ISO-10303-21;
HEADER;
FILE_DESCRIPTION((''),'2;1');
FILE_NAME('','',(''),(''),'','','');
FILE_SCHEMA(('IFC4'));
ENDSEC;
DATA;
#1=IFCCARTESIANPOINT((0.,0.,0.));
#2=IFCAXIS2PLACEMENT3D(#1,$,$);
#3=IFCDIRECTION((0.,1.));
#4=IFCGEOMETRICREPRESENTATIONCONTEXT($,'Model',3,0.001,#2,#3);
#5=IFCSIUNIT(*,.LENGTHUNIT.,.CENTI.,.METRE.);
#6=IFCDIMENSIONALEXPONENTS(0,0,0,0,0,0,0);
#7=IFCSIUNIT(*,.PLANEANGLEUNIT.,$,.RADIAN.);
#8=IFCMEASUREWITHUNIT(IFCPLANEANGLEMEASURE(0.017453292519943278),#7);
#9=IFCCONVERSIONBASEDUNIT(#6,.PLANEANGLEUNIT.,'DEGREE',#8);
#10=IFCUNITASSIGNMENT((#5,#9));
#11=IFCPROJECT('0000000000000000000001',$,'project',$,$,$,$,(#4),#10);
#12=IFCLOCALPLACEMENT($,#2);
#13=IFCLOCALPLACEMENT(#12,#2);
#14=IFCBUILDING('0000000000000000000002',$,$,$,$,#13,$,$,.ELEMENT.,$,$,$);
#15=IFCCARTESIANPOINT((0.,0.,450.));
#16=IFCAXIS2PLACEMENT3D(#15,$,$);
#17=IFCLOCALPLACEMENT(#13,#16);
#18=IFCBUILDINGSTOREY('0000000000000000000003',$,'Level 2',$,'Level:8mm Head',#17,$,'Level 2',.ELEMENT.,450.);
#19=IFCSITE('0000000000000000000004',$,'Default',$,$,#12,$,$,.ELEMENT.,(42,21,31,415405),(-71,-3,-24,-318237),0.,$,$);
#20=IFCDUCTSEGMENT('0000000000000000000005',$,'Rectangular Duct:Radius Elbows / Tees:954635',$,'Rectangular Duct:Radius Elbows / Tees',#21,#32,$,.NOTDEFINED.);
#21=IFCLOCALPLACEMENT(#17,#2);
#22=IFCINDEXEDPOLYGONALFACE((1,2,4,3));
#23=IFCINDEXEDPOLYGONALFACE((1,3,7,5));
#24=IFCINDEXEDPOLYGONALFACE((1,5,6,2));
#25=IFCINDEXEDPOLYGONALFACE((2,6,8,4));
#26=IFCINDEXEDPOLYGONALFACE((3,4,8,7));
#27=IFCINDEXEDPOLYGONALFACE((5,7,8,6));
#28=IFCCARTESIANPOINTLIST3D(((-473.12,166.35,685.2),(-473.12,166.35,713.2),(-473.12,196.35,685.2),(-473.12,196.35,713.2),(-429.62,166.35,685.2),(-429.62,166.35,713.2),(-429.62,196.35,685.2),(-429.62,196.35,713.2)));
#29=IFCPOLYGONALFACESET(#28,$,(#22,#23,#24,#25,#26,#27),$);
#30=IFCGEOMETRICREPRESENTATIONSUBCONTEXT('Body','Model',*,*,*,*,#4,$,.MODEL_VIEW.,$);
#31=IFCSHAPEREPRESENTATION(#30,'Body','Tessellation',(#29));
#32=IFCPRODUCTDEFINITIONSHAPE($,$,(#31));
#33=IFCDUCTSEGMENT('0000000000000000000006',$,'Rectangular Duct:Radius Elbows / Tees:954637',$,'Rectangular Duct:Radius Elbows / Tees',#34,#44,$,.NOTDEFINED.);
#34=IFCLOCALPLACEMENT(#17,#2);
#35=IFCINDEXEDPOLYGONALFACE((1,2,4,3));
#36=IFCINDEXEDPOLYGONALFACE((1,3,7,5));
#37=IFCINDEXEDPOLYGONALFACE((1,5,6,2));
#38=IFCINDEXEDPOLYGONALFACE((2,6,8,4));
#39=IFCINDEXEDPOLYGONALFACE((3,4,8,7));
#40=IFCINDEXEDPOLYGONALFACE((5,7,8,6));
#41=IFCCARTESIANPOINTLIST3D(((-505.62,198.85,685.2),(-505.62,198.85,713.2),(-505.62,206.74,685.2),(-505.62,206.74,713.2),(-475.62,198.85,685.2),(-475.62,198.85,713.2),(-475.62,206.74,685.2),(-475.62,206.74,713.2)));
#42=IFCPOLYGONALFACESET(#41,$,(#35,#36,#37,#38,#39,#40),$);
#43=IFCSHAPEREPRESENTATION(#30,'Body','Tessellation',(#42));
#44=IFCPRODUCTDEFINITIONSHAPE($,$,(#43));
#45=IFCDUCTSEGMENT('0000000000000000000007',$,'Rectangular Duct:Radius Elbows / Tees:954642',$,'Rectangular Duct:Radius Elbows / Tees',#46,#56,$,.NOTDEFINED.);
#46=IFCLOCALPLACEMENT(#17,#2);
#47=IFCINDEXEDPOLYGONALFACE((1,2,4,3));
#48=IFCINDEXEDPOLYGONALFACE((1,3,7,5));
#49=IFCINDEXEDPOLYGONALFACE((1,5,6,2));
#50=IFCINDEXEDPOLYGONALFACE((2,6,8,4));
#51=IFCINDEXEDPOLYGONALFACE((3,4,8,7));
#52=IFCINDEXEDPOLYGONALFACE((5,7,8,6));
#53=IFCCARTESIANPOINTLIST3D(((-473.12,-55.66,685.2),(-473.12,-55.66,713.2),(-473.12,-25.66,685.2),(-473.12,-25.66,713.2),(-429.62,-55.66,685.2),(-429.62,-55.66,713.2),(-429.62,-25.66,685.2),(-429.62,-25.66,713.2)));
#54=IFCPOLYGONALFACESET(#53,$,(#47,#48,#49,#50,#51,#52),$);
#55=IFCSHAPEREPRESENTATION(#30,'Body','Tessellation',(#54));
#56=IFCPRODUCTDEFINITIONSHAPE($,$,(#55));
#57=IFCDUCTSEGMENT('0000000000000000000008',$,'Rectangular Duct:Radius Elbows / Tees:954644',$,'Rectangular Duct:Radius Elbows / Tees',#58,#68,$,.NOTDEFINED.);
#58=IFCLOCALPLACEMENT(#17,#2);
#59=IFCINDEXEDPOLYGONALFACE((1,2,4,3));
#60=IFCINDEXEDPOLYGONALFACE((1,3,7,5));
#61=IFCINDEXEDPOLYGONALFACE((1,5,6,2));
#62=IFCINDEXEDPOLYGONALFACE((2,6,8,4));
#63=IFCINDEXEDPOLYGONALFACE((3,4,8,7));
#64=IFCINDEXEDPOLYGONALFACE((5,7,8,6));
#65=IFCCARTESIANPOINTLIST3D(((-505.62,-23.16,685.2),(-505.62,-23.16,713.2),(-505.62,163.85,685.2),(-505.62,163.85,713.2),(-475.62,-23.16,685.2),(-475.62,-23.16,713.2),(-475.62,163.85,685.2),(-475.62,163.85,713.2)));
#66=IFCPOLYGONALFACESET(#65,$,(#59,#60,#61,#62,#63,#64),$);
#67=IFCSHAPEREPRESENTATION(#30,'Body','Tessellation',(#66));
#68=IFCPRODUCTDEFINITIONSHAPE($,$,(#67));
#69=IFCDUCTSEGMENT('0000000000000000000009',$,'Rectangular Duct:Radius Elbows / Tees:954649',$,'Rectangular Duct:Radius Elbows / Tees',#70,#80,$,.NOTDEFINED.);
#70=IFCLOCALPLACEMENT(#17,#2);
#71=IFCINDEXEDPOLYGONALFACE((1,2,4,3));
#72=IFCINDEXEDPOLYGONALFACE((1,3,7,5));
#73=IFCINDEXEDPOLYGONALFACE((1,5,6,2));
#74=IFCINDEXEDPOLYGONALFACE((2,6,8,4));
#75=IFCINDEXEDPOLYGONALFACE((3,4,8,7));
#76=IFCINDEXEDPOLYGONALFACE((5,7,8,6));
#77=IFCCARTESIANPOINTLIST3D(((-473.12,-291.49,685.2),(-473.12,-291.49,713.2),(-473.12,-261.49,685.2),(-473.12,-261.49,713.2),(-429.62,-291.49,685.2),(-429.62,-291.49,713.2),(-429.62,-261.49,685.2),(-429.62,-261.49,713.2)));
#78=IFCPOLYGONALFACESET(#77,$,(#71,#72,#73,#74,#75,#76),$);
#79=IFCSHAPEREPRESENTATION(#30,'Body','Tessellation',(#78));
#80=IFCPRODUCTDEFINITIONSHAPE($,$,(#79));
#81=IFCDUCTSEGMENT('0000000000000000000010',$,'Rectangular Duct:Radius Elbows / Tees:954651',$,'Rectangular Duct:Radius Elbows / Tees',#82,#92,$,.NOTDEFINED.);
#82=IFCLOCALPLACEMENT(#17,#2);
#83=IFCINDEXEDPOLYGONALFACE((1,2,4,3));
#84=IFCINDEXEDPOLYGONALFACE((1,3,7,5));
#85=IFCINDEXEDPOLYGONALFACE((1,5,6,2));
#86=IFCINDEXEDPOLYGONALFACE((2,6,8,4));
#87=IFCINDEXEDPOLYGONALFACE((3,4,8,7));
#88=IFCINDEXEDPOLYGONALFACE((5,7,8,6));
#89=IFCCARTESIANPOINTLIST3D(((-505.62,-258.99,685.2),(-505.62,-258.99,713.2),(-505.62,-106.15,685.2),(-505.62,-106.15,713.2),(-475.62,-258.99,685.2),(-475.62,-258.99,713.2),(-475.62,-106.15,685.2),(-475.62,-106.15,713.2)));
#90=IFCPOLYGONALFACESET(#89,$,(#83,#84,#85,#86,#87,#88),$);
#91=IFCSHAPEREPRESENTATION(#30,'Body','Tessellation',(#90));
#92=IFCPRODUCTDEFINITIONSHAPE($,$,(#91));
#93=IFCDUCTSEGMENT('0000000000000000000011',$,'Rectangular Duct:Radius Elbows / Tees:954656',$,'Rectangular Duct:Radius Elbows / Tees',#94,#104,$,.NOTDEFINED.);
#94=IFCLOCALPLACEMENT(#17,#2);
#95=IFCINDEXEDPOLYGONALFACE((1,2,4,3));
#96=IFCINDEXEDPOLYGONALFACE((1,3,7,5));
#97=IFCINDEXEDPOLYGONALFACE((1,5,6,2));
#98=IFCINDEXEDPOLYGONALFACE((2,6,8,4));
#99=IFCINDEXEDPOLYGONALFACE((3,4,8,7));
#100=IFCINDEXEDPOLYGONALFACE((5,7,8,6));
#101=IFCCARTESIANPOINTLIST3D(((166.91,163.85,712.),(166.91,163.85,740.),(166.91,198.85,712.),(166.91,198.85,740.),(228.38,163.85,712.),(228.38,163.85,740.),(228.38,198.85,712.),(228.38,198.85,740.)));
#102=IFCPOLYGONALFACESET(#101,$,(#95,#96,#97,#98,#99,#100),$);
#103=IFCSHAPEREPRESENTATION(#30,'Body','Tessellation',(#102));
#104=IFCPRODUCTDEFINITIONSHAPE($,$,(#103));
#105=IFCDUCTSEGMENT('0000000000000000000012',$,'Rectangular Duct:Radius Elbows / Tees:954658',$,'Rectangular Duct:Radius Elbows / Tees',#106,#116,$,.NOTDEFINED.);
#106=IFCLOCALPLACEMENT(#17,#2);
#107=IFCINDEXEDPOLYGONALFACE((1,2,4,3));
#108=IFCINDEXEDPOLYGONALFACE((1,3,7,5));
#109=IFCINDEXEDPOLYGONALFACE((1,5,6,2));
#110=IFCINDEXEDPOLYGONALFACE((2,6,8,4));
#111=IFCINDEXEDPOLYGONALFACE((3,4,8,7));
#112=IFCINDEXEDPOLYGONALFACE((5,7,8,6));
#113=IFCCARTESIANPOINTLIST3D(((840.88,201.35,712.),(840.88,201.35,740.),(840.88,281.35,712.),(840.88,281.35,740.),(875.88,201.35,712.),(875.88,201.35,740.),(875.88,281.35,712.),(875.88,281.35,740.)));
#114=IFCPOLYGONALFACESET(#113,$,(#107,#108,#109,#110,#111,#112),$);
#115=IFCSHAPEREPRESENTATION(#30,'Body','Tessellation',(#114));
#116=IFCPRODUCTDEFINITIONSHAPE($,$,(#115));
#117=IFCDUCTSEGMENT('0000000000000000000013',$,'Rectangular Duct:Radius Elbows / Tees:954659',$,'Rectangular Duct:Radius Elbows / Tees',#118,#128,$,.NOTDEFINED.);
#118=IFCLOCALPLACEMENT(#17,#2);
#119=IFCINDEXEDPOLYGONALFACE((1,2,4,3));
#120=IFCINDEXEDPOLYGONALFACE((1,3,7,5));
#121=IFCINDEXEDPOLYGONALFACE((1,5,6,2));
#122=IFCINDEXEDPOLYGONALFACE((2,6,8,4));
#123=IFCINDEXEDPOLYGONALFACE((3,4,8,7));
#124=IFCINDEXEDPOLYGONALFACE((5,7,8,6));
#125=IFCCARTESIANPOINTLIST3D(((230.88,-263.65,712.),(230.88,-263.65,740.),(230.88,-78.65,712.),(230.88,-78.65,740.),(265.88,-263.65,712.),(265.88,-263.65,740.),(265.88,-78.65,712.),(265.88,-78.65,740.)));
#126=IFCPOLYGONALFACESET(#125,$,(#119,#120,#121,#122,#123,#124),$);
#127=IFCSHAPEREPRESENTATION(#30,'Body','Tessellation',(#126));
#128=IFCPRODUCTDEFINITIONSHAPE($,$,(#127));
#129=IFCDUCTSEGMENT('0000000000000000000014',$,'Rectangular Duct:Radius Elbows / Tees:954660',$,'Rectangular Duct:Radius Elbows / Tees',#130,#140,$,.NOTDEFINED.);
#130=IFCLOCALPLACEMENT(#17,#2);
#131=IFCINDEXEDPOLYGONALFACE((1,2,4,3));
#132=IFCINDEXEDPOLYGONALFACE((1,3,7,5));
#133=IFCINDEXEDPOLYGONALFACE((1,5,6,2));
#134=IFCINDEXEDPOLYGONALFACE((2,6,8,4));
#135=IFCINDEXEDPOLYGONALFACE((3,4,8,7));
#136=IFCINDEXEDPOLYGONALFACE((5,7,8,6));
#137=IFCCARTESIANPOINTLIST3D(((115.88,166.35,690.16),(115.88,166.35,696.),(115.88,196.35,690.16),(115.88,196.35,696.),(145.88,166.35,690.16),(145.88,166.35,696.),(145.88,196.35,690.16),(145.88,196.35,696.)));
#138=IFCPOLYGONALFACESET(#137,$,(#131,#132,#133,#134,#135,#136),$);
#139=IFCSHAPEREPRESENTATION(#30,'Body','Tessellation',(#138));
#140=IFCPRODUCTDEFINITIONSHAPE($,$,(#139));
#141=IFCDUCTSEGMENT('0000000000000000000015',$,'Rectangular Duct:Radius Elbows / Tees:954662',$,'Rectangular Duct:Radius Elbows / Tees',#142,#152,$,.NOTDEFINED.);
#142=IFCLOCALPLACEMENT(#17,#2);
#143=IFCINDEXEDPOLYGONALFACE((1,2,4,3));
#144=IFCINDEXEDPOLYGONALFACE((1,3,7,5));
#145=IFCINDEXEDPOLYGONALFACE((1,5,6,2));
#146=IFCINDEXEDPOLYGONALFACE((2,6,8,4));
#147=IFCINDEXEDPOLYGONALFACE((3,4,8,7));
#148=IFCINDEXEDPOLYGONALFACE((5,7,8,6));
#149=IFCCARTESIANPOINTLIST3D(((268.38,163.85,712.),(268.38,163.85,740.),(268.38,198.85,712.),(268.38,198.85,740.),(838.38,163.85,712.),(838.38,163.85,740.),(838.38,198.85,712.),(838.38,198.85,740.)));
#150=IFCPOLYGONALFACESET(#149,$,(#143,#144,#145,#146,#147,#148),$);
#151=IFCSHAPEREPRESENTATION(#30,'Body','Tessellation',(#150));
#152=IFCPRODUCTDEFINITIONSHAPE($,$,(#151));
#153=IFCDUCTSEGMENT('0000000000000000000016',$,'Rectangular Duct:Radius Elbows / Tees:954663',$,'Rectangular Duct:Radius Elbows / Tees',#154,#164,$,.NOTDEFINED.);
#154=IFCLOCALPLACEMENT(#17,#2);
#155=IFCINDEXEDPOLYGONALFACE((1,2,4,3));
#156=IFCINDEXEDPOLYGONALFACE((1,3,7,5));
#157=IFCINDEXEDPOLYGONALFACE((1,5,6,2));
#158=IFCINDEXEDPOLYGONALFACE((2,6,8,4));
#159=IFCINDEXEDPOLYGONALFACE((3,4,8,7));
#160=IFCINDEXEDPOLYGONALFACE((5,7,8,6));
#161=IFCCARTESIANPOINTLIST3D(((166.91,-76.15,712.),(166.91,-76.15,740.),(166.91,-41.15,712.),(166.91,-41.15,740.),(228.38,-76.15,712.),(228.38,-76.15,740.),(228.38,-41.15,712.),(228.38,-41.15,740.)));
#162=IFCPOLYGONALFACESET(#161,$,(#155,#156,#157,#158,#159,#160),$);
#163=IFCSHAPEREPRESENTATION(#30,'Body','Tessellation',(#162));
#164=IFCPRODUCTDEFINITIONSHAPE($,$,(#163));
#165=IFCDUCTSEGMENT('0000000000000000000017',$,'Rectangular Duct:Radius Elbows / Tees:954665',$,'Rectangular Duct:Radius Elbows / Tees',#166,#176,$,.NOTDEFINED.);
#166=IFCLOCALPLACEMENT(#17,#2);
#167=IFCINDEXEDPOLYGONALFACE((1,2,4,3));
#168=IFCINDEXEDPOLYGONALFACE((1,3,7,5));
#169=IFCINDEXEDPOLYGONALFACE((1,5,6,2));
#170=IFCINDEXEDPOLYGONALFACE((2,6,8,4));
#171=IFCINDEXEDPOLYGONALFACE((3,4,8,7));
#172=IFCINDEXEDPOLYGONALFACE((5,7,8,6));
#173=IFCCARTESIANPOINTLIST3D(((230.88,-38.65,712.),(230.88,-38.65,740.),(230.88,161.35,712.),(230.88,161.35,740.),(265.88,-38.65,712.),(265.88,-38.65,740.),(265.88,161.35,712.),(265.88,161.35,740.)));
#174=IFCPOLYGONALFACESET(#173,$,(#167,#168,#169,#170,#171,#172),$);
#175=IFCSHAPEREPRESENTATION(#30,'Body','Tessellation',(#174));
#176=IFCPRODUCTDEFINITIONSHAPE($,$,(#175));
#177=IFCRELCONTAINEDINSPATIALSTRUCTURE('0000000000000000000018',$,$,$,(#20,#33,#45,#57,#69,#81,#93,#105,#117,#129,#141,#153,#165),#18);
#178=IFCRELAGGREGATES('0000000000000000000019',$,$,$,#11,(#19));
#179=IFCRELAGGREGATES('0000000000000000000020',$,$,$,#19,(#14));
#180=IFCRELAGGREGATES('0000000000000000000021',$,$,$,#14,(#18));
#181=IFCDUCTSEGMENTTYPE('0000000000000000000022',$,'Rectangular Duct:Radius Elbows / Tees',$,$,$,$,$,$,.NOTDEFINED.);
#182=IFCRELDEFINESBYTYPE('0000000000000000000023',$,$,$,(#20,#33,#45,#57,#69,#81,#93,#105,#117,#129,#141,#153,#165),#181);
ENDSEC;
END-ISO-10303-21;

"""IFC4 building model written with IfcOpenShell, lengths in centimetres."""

from ifc_helpers import new_model, entity, si_unit, converted_unit, direction, frame, origin, place, context, subcontext, project, spatial, indexed_curve, outline, extrude, type_object, element, save


model = new_model("IFC4")

# Units and contexts
model_context = context("Model", 3, precision=0.001, world=origin(), true_north=direction((0.0, 1.0)))
body_context = subcontext(model_context, "Body", "Model", "MODEL_VIEW")
ifc_project = project(units=[si_unit("LENGTHUNIT", "METRE", prefix="CENTI"), converted_unit("PLANEANGLEUNIT", "DEGREE", entity("IfcPlaneAngleMeasure", 0.017453292519943278), si_unit("PLANEANGLEUNIT", "RADIAN"), dimensions=[0, 0, 0, 0, 0, 0, 0])], contexts=[model_context])

# Site, building, storey
site_placement = place(None, origin())
site = spatial("IfcSite", under=ifc_project, at=site_placement, Name="Default", CompositionType="ELEMENT", RefLatitude=(42, 21, 31, 415405), RefLongitude=(-71, -3, -24, -318237), RefElevation=0.0)
building_placement = place(site_placement, origin())
building = spatial("IfcBuilding", under=site, at=building_placement, CompositionType="ELEMENT")
storey_placement = place(building_placement, frame((0.0, 0.0, 450.0)))
storey = spatial("IfcBuildingStorey", under=building, at=storey_placement, Name="Level 2", ObjectType="Level:8mm Head", LongName="Level 2", CompositionType="ELEMENT", Elevation=450.0)

# Duct segments
duct_segment_type_1 = type_object("IfcDuctSegmentType", Name="Rectangular Duct:Radius Elbows / Tees", PredefinedType="NOTDEFINED")
duct_segment_1_placement = place(storey_placement, origin())
element("IfcDuctSegment", 1, at=duct_segment_1_placement, inside=storey, type_object=duct_segment_type_1, Name="Rectangular Duct:Radius Elbows / Tees:954635", ObjectType="Rectangular Duct:Radius Elbows / Tees", PredefinedType="NOTDEFINED", context=body_context, shape_type="SweptSolid", body=[
    extrude(outline(indexed_curve([(-21.75, -15.0), (21.75, -15.0), (21.75, 15.0), (-21.75, 15.0), (-21.75, -15.0)], self_intersect=False)), frame((-451.37, 181.35, 685.2)), (0.0, 0.0, 1.0), 28.0),
])
duct_segment_2_placement = place(storey_placement, origin())
element("IfcDuctSegment", 2, at=duct_segment_2_placement, inside=storey, type_object=duct_segment_type_1, Name="Rectangular Duct:Radius Elbows / Tees:954637", ObjectType="Rectangular Duct:Radius Elbows / Tees", PredefinedType="NOTDEFINED", context=body_context, shape_type="SweptSolid", body=[
    extrude(outline(indexed_curve([(-3.95, -15.0), (3.95, -15.0), (3.95, 15.0), (-3.95, 15.0), (-3.95, -15.0)], self_intersect=False)), frame((-490.62, 202.79, 685.2), z_axis=(0.0, 0.0, 1.0), x_axis=(0.0, -1.0, 0.0)), (0.0, 0.0, 1.0), 28.0),
])
duct_segment_3_placement = place(storey_placement, origin())
element("IfcDuctSegment", 3, at=duct_segment_3_placement, inside=storey, type_object=duct_segment_type_1, Name="Rectangular Duct:Radius Elbows / Tees:954642", ObjectType="Rectangular Duct:Radius Elbows / Tees", PredefinedType="NOTDEFINED", context=body_context, shape_type="SweptSolid", body=[
    extrude(outline(indexed_curve([(-21.75, -15.0), (21.75, -15.0), (21.75, 15.0), (-21.75, 15.0), (-21.75, -15.0)], self_intersect=False)), frame((-451.37, -40.66, 685.2)), (0.0, 0.0, 1.0), 28.0),
])
duct_segment_4_placement = place(storey_placement, origin())
element("IfcDuctSegment", 4, at=duct_segment_4_placement, inside=storey, type_object=duct_segment_type_1, Name="Rectangular Duct:Radius Elbows / Tees:954644", ObjectType="Rectangular Duct:Radius Elbows / Tees", PredefinedType="NOTDEFINED", context=body_context, shape_type="SweptSolid", body=[
    extrude(outline(indexed_curve([(-93.5, -15.0), (93.5, -15.0), (93.5, 15.0), (-93.5, 15.0), (-93.5, -15.0)], self_intersect=False)), frame((-490.62, 70.34, 685.2), z_axis=(0.0, 0.0, 1.0), x_axis=(0.0, -1.0, 0.0)), (0.0, 0.0, 1.0), 28.0),
])
duct_segment_5_placement = place(storey_placement, origin())
element("IfcDuctSegment", 5, at=duct_segment_5_placement, inside=storey, type_object=duct_segment_type_1, Name="Rectangular Duct:Radius Elbows / Tees:954649", ObjectType="Rectangular Duct:Radius Elbows / Tees", PredefinedType="NOTDEFINED", context=body_context, shape_type="SweptSolid", body=[
    extrude(outline(indexed_curve([(-21.75, -15.0), (21.75, -15.0), (21.75, 15.0), (-21.75, 15.0), (-21.75, -15.0)], self_intersect=False)), frame((-451.37, -276.49, 685.2)), (0.0, 0.0, 1.0), 28.0),
])
duct_segment_6_placement = place(storey_placement, origin())
element("IfcDuctSegment", 6, at=duct_segment_6_placement, inside=storey, type_object=duct_segment_type_1, Name="Rectangular Duct:Radius Elbows / Tees:954651", ObjectType="Rectangular Duct:Radius Elbows / Tees", PredefinedType="NOTDEFINED", context=body_context, shape_type="SweptSolid", body=[
    extrude(outline(indexed_curve([(-76.42, -15.0), (76.42, -15.0), (76.42, 15.0), (-76.42, 15.0), (-76.42, -15.0)], self_intersect=False)), frame((-490.62, -182.57, 685.2), z_axis=(0.0, 0.0, 1.0), x_axis=(0.0, -1.0, 0.0)), (0.0, 0.0, 1.0), 28.0),
])
duct_segment_7_placement = place(storey_placement, origin())
element("IfcDuctSegment", 7, at=duct_segment_7_placement, inside=storey, type_object=duct_segment_type_1, Name="Rectangular Duct:Radius Elbows / Tees:954656", ObjectType="Rectangular Duct:Radius Elbows / Tees", PredefinedType="NOTDEFINED", context=body_context, shape_type="SweptSolid", body=[
    extrude(outline(indexed_curve([(-30.73, -17.5), (30.73, -17.5), (30.73, 17.5), (-30.73, 17.5), (-30.73, -17.5)], self_intersect=False)), frame((197.64, 181.35, 712.0), z_axis=(0.0, 0.0, 1.0), x_axis=(-1.0, 0.0, 0.0)), (0.0, 0.0, 1.0), 28.0),
])
duct_segment_8_placement = place(storey_placement, origin())
element("IfcDuctSegment", 8, at=duct_segment_8_placement, inside=storey, type_object=duct_segment_type_1, Name="Rectangular Duct:Radius Elbows / Tees:954658", ObjectType="Rectangular Duct:Radius Elbows / Tees", PredefinedType="NOTDEFINED", context=body_context, shape_type="SweptSolid", body=[
    extrude(outline(indexed_curve([(-40.0, -17.5), (40.0, -17.5), (40.0, 17.5), (-40.0, 17.5), (-40.0, -17.5)], self_intersect=False)), frame((858.38, 241.35, 712.0), z_axis=(0.0, 0.0, 1.0), x_axis=(0.0, -1.0, 0.0)), (0.0, 0.0, 1.0), 28.0),
])
duct_segment_9_placement = place(storey_placement, origin())
element("IfcDuctSegment", 9, at=duct_segment_9_placement, inside=storey, type_object=duct_segment_type_1, Name="Rectangular Duct:Radius Elbows / Tees:954659", ObjectType="Rectangular Duct:Radius Elbows / Tees", PredefinedType="NOTDEFINED", context=body_context, shape_type="SweptSolid", body=[
    extrude(outline(indexed_curve([(-92.5, -17.5), (92.5, -17.5), (92.5, 17.5), (-92.5, 17.5), (-92.5, -17.5)], self_intersect=False)), frame((248.38, -171.15, 712.0), z_axis=(0.0, 0.0, 1.0), x_axis=(0.0, -1.0, 0.0)), (0.0, 0.0, 1.0), 28.0),
])
duct_segment_10_placement = place(storey_placement, origin())
element("IfcDuctSegment", 10, at=duct_segment_10_placement, inside=storey, type_object=duct_segment_type_1, Name="Rectangular Duct:Radius Elbows / Tees:954660", ObjectType="Rectangular Duct:Radius Elbows / Tees", PredefinedType="NOTDEFINED", context=body_context, shape_type="SweptSolid", body=[
    extrude(outline(indexed_curve([(-15.0, -15.0), (15.0, -15.0), (15.0, 15.0), (-15.0, 15.0), (-15.0, -15.0)], self_intersect=False)), frame((130.88, 181.35, 690.16)), (0.0, 0.0, 1.0), 5.84),
])
duct_segment_11_placement = place(storey_placement, origin())
element("IfcDuctSegment", 11, at=duct_segment_11_placement, inside=storey, type_object=duct_segment_type_1, Name="Rectangular Duct:Radius Elbows / Tees:954662", ObjectType="Rectangular Duct:Radius Elbows / Tees", PredefinedType="NOTDEFINED", context=body_context, shape_type="SweptSolid", body=[
    extrude(outline(indexed_curve([(-285.0, -17.5), (285.0, -17.5), (285.0, 17.5), (-285.0, 17.5), (-285.0, -17.5)], self_intersect=False)), frame((553.38, 181.35, 712.0), z_axis=(0.0, 0.0, 1.0), x_axis=(-1.0, 0.0, 0.0)), (0.0, 0.0, 1.0), 28.0),
])
duct_segment_12_placement = place(storey_placement, origin())
element("IfcDuctSegment", 12, at=duct_segment_12_placement, inside=storey, type_object=duct_segment_type_1, Name="Rectangular Duct:Radius Elbows / Tees:954663", ObjectType="Rectangular Duct:Radius Elbows / Tees", PredefinedType="NOTDEFINED", context=body_context, shape_type="SweptSolid", body=[
    extrude(outline(indexed_curve([(-30.73, -17.5), (30.73, -17.5), (30.73, 17.5), (-30.73, 17.5), (-30.73, -17.5)], self_intersect=False)), frame((197.64, -58.65, 712.0)), (0.0, 0.0, 1.0), 28.0),
])
duct_segment_13_placement = place(storey_placement, origin())
element("IfcDuctSegment", 13, at=duct_segment_13_placement, inside=storey, type_object=duct_segment_type_1, Name="Rectangular Duct:Radius Elbows / Tees:954665", ObjectType="Rectangular Duct:Radius Elbows / Tees", PredefinedType="NOTDEFINED", context=body_context, shape_type="SweptSolid", body=[
    extrude(outline(indexed_curve([(-100.0, -17.5), (100.0, -17.5), (100.0, 17.5), (-100.0, 17.5), (-100.0, -17.5)], self_intersect=False)), frame((248.38, 61.35, 712.0), z_axis=(0.0, 0.0, 1.0), x_axis=(0.0, -1.0, 0.0)), (0.0, 0.0, 1.0), 28.0),
])

save(model, "model.ifc")
